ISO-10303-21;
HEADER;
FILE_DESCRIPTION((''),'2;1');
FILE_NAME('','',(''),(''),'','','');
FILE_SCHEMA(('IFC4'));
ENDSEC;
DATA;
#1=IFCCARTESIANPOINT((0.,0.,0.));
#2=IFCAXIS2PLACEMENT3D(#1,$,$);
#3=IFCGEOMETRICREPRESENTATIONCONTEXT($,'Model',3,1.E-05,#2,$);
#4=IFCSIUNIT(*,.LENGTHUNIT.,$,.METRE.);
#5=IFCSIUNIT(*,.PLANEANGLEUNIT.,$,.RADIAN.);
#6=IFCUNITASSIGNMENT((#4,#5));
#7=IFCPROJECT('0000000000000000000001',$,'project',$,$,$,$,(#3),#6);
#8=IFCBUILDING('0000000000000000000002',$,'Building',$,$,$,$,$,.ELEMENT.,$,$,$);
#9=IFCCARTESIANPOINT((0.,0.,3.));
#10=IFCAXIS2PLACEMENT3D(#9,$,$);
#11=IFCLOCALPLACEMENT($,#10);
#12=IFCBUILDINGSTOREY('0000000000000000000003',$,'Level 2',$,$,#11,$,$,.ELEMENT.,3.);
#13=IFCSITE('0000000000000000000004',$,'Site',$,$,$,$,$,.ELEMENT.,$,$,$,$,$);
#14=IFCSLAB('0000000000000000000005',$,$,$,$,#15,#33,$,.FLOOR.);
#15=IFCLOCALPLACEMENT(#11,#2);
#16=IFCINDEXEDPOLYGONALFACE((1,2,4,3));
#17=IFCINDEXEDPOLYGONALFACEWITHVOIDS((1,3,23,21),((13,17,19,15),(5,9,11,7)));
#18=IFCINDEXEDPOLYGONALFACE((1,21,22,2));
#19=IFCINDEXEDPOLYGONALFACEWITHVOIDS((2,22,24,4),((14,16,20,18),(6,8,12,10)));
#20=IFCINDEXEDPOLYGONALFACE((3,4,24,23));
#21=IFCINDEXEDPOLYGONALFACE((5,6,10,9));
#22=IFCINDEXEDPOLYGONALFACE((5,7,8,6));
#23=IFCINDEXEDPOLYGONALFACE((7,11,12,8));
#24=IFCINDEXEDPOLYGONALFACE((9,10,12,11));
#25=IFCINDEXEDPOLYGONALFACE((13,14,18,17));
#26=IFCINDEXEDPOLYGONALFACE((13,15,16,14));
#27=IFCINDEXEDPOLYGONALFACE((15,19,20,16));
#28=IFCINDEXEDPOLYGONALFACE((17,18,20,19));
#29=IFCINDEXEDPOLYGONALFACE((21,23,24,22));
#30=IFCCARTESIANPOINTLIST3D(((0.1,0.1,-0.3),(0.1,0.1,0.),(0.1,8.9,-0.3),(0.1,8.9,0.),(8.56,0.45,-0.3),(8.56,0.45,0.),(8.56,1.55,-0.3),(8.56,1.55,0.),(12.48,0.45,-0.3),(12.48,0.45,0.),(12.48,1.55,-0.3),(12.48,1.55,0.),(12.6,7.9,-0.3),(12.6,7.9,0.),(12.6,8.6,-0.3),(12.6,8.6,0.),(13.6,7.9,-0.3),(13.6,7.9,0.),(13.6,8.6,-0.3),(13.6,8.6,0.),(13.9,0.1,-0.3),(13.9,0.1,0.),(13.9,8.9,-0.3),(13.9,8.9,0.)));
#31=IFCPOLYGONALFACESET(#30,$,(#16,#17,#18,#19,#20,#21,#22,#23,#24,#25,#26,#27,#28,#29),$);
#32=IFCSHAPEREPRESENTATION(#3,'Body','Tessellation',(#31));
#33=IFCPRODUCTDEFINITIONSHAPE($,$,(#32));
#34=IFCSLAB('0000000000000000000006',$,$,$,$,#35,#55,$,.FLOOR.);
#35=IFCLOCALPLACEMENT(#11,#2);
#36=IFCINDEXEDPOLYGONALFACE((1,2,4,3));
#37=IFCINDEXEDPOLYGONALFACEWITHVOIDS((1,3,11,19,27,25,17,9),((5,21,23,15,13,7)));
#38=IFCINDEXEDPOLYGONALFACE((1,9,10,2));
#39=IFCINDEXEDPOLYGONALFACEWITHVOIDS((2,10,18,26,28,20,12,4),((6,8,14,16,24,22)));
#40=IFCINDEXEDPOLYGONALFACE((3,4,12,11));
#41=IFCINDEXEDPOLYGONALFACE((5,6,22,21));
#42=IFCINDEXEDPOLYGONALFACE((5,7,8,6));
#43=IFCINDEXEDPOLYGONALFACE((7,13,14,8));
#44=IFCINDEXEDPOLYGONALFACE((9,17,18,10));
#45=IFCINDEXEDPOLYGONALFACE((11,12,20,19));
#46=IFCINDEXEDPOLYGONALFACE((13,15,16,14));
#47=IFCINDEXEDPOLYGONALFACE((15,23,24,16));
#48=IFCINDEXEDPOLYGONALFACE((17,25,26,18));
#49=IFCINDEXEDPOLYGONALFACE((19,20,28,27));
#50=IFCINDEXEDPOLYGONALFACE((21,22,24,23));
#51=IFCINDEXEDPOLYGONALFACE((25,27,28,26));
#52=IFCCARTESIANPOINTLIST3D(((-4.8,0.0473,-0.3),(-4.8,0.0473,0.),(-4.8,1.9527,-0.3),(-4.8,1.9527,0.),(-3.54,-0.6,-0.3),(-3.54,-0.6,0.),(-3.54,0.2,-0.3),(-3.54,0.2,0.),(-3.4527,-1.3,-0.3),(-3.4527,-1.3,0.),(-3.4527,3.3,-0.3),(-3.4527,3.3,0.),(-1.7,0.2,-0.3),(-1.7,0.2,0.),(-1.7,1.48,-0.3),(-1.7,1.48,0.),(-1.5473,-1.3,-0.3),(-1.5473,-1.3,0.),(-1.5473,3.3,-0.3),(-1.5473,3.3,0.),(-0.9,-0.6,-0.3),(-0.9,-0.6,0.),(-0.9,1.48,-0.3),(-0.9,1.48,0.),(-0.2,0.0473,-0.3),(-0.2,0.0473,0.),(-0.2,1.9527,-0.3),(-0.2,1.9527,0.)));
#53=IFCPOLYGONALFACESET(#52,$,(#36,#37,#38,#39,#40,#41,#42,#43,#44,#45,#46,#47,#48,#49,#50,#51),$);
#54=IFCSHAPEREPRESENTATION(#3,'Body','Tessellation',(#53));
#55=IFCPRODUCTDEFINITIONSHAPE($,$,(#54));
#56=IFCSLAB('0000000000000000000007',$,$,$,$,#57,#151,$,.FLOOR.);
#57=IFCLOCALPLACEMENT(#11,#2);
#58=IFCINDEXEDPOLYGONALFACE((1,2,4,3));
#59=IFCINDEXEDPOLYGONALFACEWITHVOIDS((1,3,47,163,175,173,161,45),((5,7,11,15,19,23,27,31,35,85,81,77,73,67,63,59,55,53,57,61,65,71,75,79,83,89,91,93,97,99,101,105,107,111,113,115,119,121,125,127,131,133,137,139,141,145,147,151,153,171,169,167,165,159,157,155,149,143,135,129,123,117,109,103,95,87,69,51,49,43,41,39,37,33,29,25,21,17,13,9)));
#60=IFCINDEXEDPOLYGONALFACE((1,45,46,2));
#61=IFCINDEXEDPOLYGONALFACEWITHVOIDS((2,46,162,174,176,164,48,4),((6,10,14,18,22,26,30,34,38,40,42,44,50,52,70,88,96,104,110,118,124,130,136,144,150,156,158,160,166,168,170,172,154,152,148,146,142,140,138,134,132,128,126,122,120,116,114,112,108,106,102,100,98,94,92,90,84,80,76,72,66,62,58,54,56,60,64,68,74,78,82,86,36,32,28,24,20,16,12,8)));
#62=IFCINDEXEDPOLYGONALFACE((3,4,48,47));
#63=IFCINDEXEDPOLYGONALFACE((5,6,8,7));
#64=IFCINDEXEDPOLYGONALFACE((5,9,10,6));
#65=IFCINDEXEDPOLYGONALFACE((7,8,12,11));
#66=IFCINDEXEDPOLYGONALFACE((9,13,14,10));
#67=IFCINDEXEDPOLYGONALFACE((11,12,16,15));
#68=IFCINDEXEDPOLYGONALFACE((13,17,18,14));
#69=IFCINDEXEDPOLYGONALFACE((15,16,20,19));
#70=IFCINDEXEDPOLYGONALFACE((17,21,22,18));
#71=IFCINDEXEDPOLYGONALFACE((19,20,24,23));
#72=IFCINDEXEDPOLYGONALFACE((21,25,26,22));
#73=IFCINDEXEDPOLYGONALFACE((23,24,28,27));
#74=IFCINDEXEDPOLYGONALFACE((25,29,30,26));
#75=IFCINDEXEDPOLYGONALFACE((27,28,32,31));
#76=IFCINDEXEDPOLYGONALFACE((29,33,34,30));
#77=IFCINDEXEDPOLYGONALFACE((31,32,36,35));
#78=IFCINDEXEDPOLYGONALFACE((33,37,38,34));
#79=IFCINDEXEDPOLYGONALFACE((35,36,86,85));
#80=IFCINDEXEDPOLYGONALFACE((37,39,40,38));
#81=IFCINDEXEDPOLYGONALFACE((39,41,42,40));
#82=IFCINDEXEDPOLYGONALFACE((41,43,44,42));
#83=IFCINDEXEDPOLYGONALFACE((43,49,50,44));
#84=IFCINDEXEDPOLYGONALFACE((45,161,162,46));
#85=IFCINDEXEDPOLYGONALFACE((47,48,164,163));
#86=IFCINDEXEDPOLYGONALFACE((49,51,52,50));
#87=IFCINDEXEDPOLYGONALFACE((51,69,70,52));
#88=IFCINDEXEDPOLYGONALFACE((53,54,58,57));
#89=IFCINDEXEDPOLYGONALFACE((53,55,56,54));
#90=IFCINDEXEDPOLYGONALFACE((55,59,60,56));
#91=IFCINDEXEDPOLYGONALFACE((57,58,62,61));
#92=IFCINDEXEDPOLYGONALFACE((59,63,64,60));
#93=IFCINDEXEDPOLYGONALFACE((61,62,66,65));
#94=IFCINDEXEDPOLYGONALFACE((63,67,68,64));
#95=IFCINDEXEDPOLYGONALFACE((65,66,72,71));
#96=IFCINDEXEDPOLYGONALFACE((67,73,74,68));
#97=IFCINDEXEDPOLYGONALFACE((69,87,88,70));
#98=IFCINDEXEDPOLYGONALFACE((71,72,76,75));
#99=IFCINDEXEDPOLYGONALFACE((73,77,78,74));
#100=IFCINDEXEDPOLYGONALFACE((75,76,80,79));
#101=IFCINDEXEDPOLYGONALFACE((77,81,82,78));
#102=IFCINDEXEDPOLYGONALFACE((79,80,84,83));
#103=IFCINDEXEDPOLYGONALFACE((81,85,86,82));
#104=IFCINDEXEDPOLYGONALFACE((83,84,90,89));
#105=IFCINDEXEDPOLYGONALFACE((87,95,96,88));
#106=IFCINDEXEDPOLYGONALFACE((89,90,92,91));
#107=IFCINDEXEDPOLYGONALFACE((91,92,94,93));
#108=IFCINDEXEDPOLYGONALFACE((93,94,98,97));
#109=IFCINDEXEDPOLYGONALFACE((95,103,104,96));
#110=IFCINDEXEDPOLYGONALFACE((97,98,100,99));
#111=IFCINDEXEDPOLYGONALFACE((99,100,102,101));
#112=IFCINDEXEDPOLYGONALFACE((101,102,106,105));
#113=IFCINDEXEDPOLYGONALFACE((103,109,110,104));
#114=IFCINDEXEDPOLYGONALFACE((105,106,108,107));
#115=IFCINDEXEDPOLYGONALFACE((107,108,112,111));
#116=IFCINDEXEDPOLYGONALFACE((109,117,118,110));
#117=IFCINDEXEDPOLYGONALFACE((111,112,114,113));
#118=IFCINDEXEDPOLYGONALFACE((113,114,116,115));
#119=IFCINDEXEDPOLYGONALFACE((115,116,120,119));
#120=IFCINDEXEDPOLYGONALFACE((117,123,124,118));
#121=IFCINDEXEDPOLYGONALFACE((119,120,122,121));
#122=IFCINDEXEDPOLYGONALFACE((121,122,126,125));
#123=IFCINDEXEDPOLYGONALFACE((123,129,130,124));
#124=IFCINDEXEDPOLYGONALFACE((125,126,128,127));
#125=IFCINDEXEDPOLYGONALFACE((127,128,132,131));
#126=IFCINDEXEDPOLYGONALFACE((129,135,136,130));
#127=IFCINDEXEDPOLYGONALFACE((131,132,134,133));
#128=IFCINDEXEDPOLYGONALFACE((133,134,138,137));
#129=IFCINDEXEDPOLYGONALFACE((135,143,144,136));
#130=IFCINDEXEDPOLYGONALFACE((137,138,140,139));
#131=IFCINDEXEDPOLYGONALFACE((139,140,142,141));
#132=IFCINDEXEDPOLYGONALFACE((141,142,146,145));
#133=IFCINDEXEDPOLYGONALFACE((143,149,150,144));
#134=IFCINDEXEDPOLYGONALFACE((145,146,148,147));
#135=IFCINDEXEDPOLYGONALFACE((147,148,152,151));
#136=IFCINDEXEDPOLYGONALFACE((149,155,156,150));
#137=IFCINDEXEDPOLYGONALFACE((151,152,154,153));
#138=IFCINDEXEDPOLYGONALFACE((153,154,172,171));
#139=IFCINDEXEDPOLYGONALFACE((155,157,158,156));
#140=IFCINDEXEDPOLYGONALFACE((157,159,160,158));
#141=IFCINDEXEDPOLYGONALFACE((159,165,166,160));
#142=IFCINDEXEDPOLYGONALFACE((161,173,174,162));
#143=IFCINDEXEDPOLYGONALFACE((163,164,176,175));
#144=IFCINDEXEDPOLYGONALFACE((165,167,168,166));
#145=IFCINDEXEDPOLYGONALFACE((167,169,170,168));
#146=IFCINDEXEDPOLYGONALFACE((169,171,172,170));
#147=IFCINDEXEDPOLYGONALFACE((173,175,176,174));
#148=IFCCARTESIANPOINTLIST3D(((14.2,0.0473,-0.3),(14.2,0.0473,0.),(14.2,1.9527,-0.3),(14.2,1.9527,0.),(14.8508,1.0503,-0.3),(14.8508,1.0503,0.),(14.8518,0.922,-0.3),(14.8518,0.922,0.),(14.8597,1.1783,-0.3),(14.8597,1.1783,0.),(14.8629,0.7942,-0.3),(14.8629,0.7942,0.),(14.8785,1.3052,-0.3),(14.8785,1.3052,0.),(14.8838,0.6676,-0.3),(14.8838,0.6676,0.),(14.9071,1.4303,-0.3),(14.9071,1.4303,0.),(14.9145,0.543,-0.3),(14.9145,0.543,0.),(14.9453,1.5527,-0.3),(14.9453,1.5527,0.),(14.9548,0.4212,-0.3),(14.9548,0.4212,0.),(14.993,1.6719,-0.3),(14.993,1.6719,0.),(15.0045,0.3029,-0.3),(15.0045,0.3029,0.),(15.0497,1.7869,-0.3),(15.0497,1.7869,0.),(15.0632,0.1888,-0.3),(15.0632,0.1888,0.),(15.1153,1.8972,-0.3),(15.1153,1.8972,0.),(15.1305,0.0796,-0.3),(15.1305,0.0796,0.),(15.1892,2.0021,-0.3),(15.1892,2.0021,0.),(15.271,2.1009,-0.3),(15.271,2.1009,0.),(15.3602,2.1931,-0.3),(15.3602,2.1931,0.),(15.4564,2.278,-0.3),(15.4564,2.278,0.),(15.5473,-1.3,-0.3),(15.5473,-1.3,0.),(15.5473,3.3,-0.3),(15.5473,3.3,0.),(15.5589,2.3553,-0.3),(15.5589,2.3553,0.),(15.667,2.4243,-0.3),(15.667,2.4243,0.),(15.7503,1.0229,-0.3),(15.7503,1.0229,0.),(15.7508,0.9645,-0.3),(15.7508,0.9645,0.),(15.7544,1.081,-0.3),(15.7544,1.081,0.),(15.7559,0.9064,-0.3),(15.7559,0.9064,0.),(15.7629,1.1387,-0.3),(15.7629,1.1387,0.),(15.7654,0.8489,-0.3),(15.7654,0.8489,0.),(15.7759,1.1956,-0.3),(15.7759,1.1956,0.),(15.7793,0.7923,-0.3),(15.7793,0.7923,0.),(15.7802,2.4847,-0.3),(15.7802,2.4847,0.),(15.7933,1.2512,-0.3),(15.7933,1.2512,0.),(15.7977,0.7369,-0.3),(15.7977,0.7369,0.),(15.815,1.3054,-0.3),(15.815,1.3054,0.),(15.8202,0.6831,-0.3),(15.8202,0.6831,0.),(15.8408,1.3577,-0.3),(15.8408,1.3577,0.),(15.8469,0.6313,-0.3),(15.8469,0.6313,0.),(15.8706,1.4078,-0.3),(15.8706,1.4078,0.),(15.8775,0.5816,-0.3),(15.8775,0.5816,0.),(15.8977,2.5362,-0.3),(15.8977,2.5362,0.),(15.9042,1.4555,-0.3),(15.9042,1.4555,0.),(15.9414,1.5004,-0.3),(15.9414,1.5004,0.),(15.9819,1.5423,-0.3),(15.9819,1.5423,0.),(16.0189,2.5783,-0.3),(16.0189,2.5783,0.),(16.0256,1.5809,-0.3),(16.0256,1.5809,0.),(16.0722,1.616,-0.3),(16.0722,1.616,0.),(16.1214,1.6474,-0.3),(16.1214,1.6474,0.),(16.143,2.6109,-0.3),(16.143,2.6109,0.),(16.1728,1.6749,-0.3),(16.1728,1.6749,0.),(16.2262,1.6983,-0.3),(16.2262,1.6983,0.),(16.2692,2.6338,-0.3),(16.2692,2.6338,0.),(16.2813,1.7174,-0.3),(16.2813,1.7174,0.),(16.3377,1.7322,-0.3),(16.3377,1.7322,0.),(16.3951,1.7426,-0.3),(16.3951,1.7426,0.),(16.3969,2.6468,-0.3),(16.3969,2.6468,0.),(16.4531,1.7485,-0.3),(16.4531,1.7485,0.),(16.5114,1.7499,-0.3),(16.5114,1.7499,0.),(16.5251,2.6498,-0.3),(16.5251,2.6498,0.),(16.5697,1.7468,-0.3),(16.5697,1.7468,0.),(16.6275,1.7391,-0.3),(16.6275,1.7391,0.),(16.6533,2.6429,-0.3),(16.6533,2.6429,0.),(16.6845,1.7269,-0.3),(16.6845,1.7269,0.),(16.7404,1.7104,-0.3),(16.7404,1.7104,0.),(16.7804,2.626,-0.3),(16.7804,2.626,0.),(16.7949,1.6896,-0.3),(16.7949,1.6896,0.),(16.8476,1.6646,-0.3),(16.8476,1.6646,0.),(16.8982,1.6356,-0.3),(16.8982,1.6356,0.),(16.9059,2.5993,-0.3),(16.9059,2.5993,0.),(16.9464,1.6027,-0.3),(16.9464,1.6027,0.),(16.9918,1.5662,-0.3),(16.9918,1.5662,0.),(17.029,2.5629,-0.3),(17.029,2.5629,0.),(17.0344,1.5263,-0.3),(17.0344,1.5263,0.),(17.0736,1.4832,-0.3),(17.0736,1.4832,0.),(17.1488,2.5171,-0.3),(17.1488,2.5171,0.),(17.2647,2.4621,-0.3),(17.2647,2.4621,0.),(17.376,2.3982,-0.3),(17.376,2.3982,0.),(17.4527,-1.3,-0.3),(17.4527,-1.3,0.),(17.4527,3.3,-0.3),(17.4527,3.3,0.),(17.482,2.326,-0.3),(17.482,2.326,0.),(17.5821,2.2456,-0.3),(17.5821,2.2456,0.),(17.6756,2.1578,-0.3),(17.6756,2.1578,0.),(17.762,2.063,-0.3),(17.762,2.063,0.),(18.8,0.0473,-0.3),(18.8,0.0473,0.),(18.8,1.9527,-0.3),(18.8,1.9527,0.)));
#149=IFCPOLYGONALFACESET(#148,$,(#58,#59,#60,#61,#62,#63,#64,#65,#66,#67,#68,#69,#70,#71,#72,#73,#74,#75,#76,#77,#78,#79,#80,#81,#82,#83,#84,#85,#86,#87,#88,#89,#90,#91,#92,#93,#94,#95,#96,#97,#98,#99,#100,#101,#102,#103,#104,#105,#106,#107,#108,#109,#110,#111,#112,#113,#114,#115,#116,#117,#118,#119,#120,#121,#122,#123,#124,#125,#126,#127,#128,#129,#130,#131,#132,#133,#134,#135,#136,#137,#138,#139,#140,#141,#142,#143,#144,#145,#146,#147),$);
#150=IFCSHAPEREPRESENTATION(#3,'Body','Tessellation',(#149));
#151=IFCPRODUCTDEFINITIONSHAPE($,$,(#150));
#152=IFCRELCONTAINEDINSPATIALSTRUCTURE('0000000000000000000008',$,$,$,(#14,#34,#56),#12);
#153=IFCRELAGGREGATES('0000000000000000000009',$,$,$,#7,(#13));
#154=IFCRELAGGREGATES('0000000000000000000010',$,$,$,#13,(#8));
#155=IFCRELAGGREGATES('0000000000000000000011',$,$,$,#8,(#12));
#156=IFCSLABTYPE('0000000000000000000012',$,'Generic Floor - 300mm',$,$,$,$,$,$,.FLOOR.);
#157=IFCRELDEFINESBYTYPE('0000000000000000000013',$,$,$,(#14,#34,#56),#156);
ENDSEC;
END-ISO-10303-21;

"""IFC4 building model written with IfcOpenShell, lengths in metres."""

from ifc_helpers import new_model, si_unit, frame, origin, place, context, project, spatial, polyline, outline, extrude, type_object, element, save


model = new_model("IFC4")

# Units and contexts
model_context = context("Model", 3, precision=1e-05, world=origin())
ifc_project = project(units=[si_unit("LENGTHUNIT", "METRE"), si_unit("PLANEANGLEUNIT", "RADIAN")], contexts=[model_context])

# Site, building, storey
site = spatial("IfcSite", under=ifc_project, Name="Site", CompositionType="ELEMENT")
building = spatial("IfcBuilding", under=site, Name="Building", CompositionType="ELEMENT")
storey_placement = place(None, frame((0.0, 0.0, 3.0)))
storey = spatial("IfcBuildingStorey", under=building, at=storey_placement, Name="Level 2", CompositionType="ELEMENT", Elevation=3.0)

# Slab, openings
slab_type = type_object("IfcSlabType", Name="Generic Floor - 300mm", PredefinedType="FLOOR")
slab_1_placement = place(None, frame((0.0, 0.0, 3.0)))
slab_1 = element("IfcSlab", 1, at=slab_1_placement, inside=storey, type_object=slab_type, PredefinedType="FLOOR", context=model_context, shape_type="SweptSolid", body=[
    extrude(outline(polyline([(0.1, 0.1), (13.9, 0.1), (13.9, 8.9), (0.1, 8.9), (0.1, 0.1)])), origin(), (0.0, 0.0, -1.0), 0.3),
])
opening_1_placement = place(None, frame((0.0, 0.0, 3.001)))
element("IfcOpeningElement", 2, at=opening_1_placement, cuts=slab_1, PredefinedType="OPENING", context=model_context, shape_type="SweptSolid", body=[
    extrude(outline(polyline([(8.56, 1.55), (8.56, 0.45), (12.48, 0.45), (12.48, 1.55), (8.56, 1.55)])), origin(), (0.0, 0.0, -1.0), 0.302),
])
opening_2_placement = place(None, frame((0.0, 0.0, 3.001)))
element("IfcOpeningElement", 3, at=opening_2_placement, cuts=slab_1, PredefinedType="OPENING", context=model_context, shape_type="SweptSolid", body=[
    extrude(outline(polyline([(12.6, 7.9), (13.6, 7.9), (13.6, 8.6), (12.6, 8.6), (12.6, 7.9)])), origin(), (0.0, 0.0, -1.0), 0.302),
])

# Slabs, openings
slab_2_placement = place(None, frame((0.0, 0.0, 3.0)))
slab_2 = element("IfcSlab", 4, at=slab_2_placement, inside=storey, type_object=slab_type, PredefinedType="FLOOR", context=model_context, shape_type="SweptSolid", body=[
    extrude(outline(polyline([(-0.2, 1.9527), (-1.5473, 3.3), (-3.4527, 3.3), (-4.8, 1.9527), (-4.8, 0.0473), (-3.4527, -1.3), (-1.5473, -1.3), (-0.2, 0.0473), (-0.2, 1.9527)])), origin(), (0.0, 0.0, -1.0), 0.3),
])
opening_3_placement = place(None, frame((0.0, 0.0, 3.001)))
element("IfcOpeningElement", 5, at=opening_3_placement, cuts=slab_2, PredefinedType="OPENING", context=model_context, shape_type="SweptSolid", body=[
    extrude(outline(polyline([(-3.54, 0.2), (-3.54, -0.6), (-0.9, -0.6), (-0.9, 1.48), (-1.7, 1.48), (-1.7, 0.2), (-3.54, 0.2)])), origin(), (0.0, 0.0, -1.0), 0.302),
])
slab_3_placement = place(None, frame((0.0, 0.0, 3.0)))
slab_3 = element("IfcSlab", 6, at=slab_3_placement, inside=storey, type_object=slab_type, PredefinedType="FLOOR", context=model_context, shape_type="SweptSolid", body=[
    extrude(outline(polyline([(18.8, 1.9527), (17.4527, 3.3), (15.5473, 3.3), (14.2, 1.9527), (14.2, 0.0473), (15.5473, -1.3), (17.4527, -1.3), (18.8, 0.0473), (18.8, 1.9527)])), origin(), (0.0, 0.0, -1.0), 0.3),
])
opening_4_placement = place(None, frame((0.0, 0.0, 3.001)))
element("IfcOpeningElement", 7, at=opening_4_placement, cuts=slab_3, PredefinedType="OPENING", context=model_context, shape_type="SweptSolid", body=[
    extrude(outline(polyline([(14.8597, 1.1783), (14.8508, 1.0503), (14.8518, 0.922), (14.8629, 0.7942), (14.8838, 0.6676), (14.9145, 0.543), (14.9548, 0.4212), (15.0045, 0.3029), (15.0632, 0.1888), (15.1305, 0.0796), (15.8775, 0.5816), (15.8469, 0.6313), (15.8202, 0.6831), (15.7977, 0.7369), (15.7793, 0.7923), (15.7654, 0.8489), (15.7559, 0.9064), (15.7508, 0.9645), (15.7503, 1.0229), (15.7544, 1.081), (15.7629, 1.1387), (15.7759, 1.1956), (15.7933, 1.2512), (15.815, 1.3054), (15.8408, 1.3577), (15.8706, 1.4078), (15.9042, 1.4555), (15.9414, 1.5004), (15.9819, 1.5423), (16.0256, 1.5809), (16.0722, 1.616), (16.1214, 1.6474), (16.1728, 1.6749), (16.2262, 1.6983), (16.2813, 1.7174), (16.3377, 1.7322), (16.3951, 1.7426), (16.4531, 1.7485), (16.5114, 1.7499), (16.5697, 1.7468), (16.6275, 1.7391), (16.6845, 1.7269), (16.7404, 1.7104), (16.7949, 1.6896), (16.8476, 1.6646), (16.8982, 1.6356), (16.9464, 1.6027), (16.9918, 1.5662), (17.0344, 1.5263), (17.0736, 1.4832), (17.762, 2.063), (17.6756, 2.1578), (17.5821, 2.2456), (17.482, 2.326), (17.376, 2.3982), (17.2647, 2.4621), (17.1488, 2.5171), (17.029, 2.5629), (16.9059, 2.5993), (16.7804, 2.626), (16.6533, 2.6429), (16.5251, 2.6498), (16.3969, 2.6468), (16.2692, 2.6338), (16.143, 2.6109), (16.0189, 2.5783), (15.8977, 2.5362), (15.7802, 2.4847), (15.667, 2.4243), (15.5589, 2.3553), (15.4564, 2.278), (15.3602, 2.1931), (15.271, 2.1009), (15.1892, 2.0021), (15.1153, 1.8972), (15.0497, 1.7869), (14.993, 1.6719), (14.9453, 1.5527), (14.9071, 1.4303), (14.8785, 1.3052), (14.8597, 1.1783)])), origin(), (0.0, 0.0, -1.0), 0.302),
])

save(model, "model.ifc")
